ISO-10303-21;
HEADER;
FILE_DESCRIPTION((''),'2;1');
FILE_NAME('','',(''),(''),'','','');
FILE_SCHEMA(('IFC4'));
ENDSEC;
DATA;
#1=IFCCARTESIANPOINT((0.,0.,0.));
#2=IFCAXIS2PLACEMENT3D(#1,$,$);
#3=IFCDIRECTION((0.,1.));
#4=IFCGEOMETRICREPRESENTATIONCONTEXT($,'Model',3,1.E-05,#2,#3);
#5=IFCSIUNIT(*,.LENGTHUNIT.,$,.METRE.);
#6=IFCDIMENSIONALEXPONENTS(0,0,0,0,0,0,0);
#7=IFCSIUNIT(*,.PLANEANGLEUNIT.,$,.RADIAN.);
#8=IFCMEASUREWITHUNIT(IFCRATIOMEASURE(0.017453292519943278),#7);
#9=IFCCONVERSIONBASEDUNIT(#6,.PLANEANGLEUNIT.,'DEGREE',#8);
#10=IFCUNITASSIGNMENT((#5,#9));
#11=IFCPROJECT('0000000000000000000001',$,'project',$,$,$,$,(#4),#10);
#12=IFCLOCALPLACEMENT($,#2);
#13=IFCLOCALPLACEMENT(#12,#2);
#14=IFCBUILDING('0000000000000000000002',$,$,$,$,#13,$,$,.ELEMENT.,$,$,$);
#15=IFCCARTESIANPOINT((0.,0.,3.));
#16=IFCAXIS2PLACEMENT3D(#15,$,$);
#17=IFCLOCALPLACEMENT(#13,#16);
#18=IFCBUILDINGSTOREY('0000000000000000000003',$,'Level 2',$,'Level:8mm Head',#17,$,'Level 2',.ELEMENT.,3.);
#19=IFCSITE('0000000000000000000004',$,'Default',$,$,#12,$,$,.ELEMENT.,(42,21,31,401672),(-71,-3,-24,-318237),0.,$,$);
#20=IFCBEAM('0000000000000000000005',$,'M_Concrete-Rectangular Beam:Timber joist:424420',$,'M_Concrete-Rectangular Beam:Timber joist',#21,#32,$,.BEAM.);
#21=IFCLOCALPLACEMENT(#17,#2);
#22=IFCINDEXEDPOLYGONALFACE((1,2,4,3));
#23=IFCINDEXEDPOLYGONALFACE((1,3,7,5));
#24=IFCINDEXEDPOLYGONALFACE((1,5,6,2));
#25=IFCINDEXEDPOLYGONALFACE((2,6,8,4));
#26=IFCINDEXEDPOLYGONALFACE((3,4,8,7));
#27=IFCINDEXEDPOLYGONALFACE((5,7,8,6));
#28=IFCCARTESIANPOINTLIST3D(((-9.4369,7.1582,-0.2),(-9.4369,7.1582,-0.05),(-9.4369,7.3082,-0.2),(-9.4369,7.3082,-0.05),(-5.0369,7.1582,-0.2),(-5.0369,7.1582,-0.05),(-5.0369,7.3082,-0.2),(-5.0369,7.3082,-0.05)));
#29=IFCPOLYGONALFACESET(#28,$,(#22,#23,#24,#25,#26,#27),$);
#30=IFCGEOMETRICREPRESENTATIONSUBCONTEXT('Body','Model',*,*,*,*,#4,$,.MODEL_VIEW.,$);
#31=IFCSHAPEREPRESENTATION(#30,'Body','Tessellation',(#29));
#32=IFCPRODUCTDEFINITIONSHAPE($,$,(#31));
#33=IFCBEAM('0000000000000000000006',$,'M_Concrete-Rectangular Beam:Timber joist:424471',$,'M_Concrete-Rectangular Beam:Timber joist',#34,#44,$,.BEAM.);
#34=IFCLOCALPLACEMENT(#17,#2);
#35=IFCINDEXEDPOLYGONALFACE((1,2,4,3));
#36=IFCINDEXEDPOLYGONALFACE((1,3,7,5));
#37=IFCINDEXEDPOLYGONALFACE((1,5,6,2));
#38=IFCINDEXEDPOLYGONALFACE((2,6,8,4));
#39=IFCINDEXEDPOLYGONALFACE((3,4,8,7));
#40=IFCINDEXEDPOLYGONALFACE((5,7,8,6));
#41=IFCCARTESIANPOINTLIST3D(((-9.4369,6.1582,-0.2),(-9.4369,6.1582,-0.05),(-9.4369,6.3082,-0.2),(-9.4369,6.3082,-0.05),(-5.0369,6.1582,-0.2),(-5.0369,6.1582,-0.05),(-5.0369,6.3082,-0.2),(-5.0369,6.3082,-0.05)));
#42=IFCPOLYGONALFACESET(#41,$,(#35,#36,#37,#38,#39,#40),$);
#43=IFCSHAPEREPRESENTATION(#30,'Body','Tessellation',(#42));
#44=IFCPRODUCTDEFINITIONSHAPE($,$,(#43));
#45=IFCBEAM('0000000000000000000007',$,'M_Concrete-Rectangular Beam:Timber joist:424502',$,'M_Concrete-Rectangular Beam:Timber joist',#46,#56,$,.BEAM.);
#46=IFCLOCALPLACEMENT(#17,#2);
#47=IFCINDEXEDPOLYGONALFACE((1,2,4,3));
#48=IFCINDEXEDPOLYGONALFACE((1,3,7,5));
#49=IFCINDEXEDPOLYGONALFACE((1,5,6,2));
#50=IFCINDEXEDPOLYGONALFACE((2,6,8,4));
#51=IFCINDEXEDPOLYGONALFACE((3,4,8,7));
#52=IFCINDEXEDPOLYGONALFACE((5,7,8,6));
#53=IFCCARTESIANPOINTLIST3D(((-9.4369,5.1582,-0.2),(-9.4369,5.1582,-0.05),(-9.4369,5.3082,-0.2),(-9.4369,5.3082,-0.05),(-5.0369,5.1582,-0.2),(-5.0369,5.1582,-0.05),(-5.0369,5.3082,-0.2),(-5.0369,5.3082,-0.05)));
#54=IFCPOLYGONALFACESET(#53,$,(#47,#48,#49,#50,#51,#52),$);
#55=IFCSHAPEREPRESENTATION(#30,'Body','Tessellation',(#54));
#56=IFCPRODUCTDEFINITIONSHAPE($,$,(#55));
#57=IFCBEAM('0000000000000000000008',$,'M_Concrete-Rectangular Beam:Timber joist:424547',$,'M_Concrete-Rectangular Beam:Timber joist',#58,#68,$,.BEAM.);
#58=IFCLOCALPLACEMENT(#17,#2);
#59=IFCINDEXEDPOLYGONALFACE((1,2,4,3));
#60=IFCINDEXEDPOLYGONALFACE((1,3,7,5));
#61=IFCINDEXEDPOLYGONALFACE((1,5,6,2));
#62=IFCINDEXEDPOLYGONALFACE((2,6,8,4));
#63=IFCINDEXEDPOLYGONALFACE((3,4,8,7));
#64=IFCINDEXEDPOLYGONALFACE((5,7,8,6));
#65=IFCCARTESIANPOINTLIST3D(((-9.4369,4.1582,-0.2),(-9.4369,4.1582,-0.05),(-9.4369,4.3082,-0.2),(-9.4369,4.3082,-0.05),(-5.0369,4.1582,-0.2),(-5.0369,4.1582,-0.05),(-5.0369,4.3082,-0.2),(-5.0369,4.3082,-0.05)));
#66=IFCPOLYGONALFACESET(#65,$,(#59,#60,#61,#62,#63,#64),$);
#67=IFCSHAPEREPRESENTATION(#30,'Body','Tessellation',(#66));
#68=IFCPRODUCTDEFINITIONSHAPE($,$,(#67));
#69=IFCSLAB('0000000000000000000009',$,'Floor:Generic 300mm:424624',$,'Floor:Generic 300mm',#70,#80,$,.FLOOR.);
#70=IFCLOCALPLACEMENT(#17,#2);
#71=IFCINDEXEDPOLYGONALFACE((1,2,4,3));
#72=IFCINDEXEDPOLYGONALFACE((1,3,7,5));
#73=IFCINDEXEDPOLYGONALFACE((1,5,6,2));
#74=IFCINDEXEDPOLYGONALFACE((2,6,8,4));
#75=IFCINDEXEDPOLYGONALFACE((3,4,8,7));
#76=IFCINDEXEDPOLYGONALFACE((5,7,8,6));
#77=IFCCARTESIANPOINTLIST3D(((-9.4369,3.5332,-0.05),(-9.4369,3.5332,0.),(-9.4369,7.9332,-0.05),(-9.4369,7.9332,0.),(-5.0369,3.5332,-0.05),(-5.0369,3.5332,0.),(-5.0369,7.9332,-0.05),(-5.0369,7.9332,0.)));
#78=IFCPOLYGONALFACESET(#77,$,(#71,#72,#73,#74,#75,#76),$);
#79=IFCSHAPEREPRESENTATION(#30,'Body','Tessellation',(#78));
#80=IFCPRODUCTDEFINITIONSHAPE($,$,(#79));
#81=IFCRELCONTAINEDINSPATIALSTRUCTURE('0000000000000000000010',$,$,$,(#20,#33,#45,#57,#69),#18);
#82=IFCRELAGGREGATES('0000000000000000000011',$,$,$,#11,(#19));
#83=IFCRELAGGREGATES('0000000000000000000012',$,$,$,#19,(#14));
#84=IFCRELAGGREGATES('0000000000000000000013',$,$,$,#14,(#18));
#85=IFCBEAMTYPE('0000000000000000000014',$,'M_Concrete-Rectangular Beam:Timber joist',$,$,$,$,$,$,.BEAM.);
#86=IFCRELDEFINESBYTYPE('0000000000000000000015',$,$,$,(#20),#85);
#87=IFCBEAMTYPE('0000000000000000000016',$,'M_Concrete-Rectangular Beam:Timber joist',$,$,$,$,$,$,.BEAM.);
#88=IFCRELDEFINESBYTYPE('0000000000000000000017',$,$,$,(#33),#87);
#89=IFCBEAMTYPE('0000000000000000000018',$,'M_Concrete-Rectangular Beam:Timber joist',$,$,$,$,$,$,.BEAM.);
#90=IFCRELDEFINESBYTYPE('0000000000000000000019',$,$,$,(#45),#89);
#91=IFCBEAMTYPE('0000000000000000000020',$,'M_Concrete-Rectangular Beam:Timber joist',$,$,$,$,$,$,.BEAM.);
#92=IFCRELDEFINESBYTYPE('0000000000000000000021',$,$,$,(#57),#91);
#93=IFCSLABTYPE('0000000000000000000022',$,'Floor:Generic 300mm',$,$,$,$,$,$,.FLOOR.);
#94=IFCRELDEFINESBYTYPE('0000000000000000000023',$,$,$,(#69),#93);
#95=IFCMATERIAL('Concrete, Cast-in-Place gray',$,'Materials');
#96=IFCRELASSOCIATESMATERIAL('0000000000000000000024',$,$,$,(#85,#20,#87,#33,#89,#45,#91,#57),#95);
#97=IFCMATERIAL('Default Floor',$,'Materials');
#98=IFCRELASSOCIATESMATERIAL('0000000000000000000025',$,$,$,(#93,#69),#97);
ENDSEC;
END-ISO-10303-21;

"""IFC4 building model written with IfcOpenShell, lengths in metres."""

from ifc_helpers import new_model, entity, si_unit, converted_unit, direction, frame, origin, place, context, subcontext, project, spatial, indexed_curve, outline, extrude, source, transform, mapped, material, type_object, type_shapes, element, save


model = new_model("IFC4")

# Units and contexts
model_context = context("Model", 3, precision=1e-05, world=origin(), true_north=direction((0.0, 1.0)))
body_context = subcontext(model_context, "Body", "Model", "MODEL_VIEW")
ifc_project = project(units=[si_unit("LENGTHUNIT", "METRE"), converted_unit("PLANEANGLEUNIT", "DEGREE", entity("IfcRatioMeasure", 0.017453292519943278), si_unit("PLANEANGLEUNIT", "RADIAN"), dimensions=[0, 0, 0, 0, 0, 0, 0])], contexts=[model_context])

# Site, building, storey
site_placement = place(None, origin())
site = spatial("IfcSite", under=ifc_project, at=site_placement, Name="Default", CompositionType="ELEMENT", RefLatitude=(42, 21, 31, 401672), RefLongitude=(-71, -3, -24, -318237), RefElevation=0.0)
building_placement = place(site_placement, origin())
building = spatial("IfcBuilding", under=site, at=building_placement, CompositionType="ELEMENT")
storey_placement = place(building_placement, frame((0.0, 0.0, 3.0)))
storey = spatial("IfcBuildingStorey", under=building, at=storey_placement, Name="Level 2", ObjectType="Level:8mm Head", LongName="Level 2", CompositionType="ELEMENT", Elevation=3.0)

# Beams
ifc_material_1 = material(Name="Concrete, Cast-in-Place gray", Category="Materials")
beam_type_1 = type_object("IfcBeamType", Name="M_Concrete-Rectangular Beam:Timber joist", PredefinedType="BEAM", material=ifc_material_1)
shared_shape_1 = source(origin(), body_context, "Body", "SweptSolid", [
    extrude(outline(indexed_curve([(-0.075, -0.075), (0.075, -0.075), (0.075, 0.075), (-0.075, 0.075), (-0.075, -0.075)], self_intersect=False)), frame((-9.4369, 7.2332, 2.875), z_axis=(1.0, 0.0, 0.0), x_axis=(0.0, 0.0, -1.0)), (0.0, 0.0, 1.0), 4.4),
])
type_shapes(beam_type_1, [shared_shape_1])
beam_1_placement = place(storey_placement, frame((0.0, 0.0, -3.0)))
element("IfcBeam", 1, at=beam_1_placement, inside=storey, type_object=beam_type_1, material=ifc_material_1, Name="M_Concrete-Rectangular Beam:Timber joist:424420", ObjectType="M_Concrete-Rectangular Beam:Timber joist", PredefinedType="BEAM", context=body_context, shape_type="MappedRepresentation", body=[
    mapped(shared_shape_1, transform((0.0, 0.0, 0.0), scale=1.0)),
])
beam_type_2 = type_object("IfcBeamType", Name="M_Concrete-Rectangular Beam:Timber joist", PredefinedType="BEAM", material=ifc_material_1)
shared_shape_2 = source(origin(), body_context, "Body", "SweptSolid", [
    extrude(outline(indexed_curve([(-0.075, -0.075), (0.075, -0.075), (0.075, 0.075), (-0.075, 0.075), (-0.075, -0.075)], self_intersect=False)), frame((-9.4369, 6.2332, 2.875), z_axis=(1.0, 0.0, 0.0), x_axis=(0.0, 0.0, -1.0)), (0.0, 0.0, 1.0), 4.4),
])
type_shapes(beam_type_2, [shared_shape_2])
beam_2_placement = place(storey_placement, frame((0.0, 0.0, -3.0)))
element("IfcBeam", 2, at=beam_2_placement, inside=storey, type_object=beam_type_2, material=ifc_material_1, Name="M_Concrete-Rectangular Beam:Timber joist:424471", ObjectType="M_Concrete-Rectangular Beam:Timber joist", PredefinedType="BEAM", context=body_context, shape_type="MappedRepresentation", body=[
    mapped(shared_shape_2, transform((0.0, 0.0, 0.0), scale=1.0)),
])
beam_type_3 = type_object("IfcBeamType", Name="M_Concrete-Rectangular Beam:Timber joist", PredefinedType="BEAM", material=ifc_material_1)
shared_shape_3 = source(origin(), body_context, "Body", "SweptSolid", [
    extrude(outline(indexed_curve([(-0.075, -0.075), (0.075, -0.075), (0.075, 0.075), (-0.075, 0.075), (-0.075, -0.075)], self_intersect=False)), frame((-9.4369, 5.2332, 2.875), z_axis=(1.0, 0.0, 0.0), x_axis=(0.0, 0.0, -1.0)), (0.0, 0.0, 1.0), 4.4),
])
type_shapes(beam_type_3, [shared_shape_3])
beam_3_placement = place(storey_placement, frame((0.0, 0.0, -3.0)))
element("IfcBeam", 3, at=beam_3_placement, inside=storey, type_object=beam_type_3, material=ifc_material_1, Name="M_Concrete-Rectangular Beam:Timber joist:424502", ObjectType="M_Concrete-Rectangular Beam:Timber joist", PredefinedType="BEAM", context=body_context, shape_type="MappedRepresentation", body=[
    mapped(shared_shape_3, transform((0.0, 0.0, 0.0), scale=1.0)),
])
beam_type_4 = type_object("IfcBeamType", Name="M_Concrete-Rectangular Beam:Timber joist", PredefinedType="BEAM", material=ifc_material_1)
shared_shape_4 = source(origin(), body_context, "Body", "SweptSolid", [
    extrude(outline(indexed_curve([(-0.075, -0.075), (0.075, -0.075), (0.075, 0.075), (-0.075, 0.075), (-0.075, -0.075)], self_intersect=False)), frame((-9.4369, 4.2332, 2.875), z_axis=(1.0, 0.0, 0.0), x_axis=(0.0, 0.0, -1.0)), (0.0, 0.0, 1.0), 4.4),
])
type_shapes(beam_type_4, [shared_shape_4])
beam_4_placement = place(storey_placement, frame((0.0, 0.0, -3.0)))
element("IfcBeam", 4, at=beam_4_placement, inside=storey, type_object=beam_type_4, material=ifc_material_1, Name="M_Concrete-Rectangular Beam:Timber joist:424547", ObjectType="M_Concrete-Rectangular Beam:Timber joist", PredefinedType="BEAM", context=body_context, shape_type="MappedRepresentation", body=[
    mapped(shared_shape_4, transform((0.0, 0.0, 0.0), scale=1.0)),
])

# Slab
ifc_material_2 = material(Name="Default Floor", Category="Materials")
slab_type = type_object("IfcSlabType", Name="Floor:Generic 300mm", PredefinedType="FLOOR", material=ifc_material_2)
slab_placement = place(storey_placement, origin())
element("IfcSlab", 5, at=slab_placement, inside=storey, type_object=slab_type, material=ifc_material_2, Name="Floor:Generic 300mm:424624", ObjectType="Floor:Generic 300mm", PredefinedType="FLOOR", context=body_context, shape_type="SweptSolid", body=[
    extrude(outline(indexed_curve([(-2.2, -2.2), (2.2, -2.2), (2.2, 2.2), (-2.2, 2.2), (-2.2, -2.2)], self_intersect=False)), frame((-7.2369, 5.7332, 0.0), z_axis=(0.0, 0.0, -1.0), x_axis=(0.0, 1.0, 0.0)), (0.0, 0.0, 1.0), 0.05),
])

save(model, "model.ifc")
